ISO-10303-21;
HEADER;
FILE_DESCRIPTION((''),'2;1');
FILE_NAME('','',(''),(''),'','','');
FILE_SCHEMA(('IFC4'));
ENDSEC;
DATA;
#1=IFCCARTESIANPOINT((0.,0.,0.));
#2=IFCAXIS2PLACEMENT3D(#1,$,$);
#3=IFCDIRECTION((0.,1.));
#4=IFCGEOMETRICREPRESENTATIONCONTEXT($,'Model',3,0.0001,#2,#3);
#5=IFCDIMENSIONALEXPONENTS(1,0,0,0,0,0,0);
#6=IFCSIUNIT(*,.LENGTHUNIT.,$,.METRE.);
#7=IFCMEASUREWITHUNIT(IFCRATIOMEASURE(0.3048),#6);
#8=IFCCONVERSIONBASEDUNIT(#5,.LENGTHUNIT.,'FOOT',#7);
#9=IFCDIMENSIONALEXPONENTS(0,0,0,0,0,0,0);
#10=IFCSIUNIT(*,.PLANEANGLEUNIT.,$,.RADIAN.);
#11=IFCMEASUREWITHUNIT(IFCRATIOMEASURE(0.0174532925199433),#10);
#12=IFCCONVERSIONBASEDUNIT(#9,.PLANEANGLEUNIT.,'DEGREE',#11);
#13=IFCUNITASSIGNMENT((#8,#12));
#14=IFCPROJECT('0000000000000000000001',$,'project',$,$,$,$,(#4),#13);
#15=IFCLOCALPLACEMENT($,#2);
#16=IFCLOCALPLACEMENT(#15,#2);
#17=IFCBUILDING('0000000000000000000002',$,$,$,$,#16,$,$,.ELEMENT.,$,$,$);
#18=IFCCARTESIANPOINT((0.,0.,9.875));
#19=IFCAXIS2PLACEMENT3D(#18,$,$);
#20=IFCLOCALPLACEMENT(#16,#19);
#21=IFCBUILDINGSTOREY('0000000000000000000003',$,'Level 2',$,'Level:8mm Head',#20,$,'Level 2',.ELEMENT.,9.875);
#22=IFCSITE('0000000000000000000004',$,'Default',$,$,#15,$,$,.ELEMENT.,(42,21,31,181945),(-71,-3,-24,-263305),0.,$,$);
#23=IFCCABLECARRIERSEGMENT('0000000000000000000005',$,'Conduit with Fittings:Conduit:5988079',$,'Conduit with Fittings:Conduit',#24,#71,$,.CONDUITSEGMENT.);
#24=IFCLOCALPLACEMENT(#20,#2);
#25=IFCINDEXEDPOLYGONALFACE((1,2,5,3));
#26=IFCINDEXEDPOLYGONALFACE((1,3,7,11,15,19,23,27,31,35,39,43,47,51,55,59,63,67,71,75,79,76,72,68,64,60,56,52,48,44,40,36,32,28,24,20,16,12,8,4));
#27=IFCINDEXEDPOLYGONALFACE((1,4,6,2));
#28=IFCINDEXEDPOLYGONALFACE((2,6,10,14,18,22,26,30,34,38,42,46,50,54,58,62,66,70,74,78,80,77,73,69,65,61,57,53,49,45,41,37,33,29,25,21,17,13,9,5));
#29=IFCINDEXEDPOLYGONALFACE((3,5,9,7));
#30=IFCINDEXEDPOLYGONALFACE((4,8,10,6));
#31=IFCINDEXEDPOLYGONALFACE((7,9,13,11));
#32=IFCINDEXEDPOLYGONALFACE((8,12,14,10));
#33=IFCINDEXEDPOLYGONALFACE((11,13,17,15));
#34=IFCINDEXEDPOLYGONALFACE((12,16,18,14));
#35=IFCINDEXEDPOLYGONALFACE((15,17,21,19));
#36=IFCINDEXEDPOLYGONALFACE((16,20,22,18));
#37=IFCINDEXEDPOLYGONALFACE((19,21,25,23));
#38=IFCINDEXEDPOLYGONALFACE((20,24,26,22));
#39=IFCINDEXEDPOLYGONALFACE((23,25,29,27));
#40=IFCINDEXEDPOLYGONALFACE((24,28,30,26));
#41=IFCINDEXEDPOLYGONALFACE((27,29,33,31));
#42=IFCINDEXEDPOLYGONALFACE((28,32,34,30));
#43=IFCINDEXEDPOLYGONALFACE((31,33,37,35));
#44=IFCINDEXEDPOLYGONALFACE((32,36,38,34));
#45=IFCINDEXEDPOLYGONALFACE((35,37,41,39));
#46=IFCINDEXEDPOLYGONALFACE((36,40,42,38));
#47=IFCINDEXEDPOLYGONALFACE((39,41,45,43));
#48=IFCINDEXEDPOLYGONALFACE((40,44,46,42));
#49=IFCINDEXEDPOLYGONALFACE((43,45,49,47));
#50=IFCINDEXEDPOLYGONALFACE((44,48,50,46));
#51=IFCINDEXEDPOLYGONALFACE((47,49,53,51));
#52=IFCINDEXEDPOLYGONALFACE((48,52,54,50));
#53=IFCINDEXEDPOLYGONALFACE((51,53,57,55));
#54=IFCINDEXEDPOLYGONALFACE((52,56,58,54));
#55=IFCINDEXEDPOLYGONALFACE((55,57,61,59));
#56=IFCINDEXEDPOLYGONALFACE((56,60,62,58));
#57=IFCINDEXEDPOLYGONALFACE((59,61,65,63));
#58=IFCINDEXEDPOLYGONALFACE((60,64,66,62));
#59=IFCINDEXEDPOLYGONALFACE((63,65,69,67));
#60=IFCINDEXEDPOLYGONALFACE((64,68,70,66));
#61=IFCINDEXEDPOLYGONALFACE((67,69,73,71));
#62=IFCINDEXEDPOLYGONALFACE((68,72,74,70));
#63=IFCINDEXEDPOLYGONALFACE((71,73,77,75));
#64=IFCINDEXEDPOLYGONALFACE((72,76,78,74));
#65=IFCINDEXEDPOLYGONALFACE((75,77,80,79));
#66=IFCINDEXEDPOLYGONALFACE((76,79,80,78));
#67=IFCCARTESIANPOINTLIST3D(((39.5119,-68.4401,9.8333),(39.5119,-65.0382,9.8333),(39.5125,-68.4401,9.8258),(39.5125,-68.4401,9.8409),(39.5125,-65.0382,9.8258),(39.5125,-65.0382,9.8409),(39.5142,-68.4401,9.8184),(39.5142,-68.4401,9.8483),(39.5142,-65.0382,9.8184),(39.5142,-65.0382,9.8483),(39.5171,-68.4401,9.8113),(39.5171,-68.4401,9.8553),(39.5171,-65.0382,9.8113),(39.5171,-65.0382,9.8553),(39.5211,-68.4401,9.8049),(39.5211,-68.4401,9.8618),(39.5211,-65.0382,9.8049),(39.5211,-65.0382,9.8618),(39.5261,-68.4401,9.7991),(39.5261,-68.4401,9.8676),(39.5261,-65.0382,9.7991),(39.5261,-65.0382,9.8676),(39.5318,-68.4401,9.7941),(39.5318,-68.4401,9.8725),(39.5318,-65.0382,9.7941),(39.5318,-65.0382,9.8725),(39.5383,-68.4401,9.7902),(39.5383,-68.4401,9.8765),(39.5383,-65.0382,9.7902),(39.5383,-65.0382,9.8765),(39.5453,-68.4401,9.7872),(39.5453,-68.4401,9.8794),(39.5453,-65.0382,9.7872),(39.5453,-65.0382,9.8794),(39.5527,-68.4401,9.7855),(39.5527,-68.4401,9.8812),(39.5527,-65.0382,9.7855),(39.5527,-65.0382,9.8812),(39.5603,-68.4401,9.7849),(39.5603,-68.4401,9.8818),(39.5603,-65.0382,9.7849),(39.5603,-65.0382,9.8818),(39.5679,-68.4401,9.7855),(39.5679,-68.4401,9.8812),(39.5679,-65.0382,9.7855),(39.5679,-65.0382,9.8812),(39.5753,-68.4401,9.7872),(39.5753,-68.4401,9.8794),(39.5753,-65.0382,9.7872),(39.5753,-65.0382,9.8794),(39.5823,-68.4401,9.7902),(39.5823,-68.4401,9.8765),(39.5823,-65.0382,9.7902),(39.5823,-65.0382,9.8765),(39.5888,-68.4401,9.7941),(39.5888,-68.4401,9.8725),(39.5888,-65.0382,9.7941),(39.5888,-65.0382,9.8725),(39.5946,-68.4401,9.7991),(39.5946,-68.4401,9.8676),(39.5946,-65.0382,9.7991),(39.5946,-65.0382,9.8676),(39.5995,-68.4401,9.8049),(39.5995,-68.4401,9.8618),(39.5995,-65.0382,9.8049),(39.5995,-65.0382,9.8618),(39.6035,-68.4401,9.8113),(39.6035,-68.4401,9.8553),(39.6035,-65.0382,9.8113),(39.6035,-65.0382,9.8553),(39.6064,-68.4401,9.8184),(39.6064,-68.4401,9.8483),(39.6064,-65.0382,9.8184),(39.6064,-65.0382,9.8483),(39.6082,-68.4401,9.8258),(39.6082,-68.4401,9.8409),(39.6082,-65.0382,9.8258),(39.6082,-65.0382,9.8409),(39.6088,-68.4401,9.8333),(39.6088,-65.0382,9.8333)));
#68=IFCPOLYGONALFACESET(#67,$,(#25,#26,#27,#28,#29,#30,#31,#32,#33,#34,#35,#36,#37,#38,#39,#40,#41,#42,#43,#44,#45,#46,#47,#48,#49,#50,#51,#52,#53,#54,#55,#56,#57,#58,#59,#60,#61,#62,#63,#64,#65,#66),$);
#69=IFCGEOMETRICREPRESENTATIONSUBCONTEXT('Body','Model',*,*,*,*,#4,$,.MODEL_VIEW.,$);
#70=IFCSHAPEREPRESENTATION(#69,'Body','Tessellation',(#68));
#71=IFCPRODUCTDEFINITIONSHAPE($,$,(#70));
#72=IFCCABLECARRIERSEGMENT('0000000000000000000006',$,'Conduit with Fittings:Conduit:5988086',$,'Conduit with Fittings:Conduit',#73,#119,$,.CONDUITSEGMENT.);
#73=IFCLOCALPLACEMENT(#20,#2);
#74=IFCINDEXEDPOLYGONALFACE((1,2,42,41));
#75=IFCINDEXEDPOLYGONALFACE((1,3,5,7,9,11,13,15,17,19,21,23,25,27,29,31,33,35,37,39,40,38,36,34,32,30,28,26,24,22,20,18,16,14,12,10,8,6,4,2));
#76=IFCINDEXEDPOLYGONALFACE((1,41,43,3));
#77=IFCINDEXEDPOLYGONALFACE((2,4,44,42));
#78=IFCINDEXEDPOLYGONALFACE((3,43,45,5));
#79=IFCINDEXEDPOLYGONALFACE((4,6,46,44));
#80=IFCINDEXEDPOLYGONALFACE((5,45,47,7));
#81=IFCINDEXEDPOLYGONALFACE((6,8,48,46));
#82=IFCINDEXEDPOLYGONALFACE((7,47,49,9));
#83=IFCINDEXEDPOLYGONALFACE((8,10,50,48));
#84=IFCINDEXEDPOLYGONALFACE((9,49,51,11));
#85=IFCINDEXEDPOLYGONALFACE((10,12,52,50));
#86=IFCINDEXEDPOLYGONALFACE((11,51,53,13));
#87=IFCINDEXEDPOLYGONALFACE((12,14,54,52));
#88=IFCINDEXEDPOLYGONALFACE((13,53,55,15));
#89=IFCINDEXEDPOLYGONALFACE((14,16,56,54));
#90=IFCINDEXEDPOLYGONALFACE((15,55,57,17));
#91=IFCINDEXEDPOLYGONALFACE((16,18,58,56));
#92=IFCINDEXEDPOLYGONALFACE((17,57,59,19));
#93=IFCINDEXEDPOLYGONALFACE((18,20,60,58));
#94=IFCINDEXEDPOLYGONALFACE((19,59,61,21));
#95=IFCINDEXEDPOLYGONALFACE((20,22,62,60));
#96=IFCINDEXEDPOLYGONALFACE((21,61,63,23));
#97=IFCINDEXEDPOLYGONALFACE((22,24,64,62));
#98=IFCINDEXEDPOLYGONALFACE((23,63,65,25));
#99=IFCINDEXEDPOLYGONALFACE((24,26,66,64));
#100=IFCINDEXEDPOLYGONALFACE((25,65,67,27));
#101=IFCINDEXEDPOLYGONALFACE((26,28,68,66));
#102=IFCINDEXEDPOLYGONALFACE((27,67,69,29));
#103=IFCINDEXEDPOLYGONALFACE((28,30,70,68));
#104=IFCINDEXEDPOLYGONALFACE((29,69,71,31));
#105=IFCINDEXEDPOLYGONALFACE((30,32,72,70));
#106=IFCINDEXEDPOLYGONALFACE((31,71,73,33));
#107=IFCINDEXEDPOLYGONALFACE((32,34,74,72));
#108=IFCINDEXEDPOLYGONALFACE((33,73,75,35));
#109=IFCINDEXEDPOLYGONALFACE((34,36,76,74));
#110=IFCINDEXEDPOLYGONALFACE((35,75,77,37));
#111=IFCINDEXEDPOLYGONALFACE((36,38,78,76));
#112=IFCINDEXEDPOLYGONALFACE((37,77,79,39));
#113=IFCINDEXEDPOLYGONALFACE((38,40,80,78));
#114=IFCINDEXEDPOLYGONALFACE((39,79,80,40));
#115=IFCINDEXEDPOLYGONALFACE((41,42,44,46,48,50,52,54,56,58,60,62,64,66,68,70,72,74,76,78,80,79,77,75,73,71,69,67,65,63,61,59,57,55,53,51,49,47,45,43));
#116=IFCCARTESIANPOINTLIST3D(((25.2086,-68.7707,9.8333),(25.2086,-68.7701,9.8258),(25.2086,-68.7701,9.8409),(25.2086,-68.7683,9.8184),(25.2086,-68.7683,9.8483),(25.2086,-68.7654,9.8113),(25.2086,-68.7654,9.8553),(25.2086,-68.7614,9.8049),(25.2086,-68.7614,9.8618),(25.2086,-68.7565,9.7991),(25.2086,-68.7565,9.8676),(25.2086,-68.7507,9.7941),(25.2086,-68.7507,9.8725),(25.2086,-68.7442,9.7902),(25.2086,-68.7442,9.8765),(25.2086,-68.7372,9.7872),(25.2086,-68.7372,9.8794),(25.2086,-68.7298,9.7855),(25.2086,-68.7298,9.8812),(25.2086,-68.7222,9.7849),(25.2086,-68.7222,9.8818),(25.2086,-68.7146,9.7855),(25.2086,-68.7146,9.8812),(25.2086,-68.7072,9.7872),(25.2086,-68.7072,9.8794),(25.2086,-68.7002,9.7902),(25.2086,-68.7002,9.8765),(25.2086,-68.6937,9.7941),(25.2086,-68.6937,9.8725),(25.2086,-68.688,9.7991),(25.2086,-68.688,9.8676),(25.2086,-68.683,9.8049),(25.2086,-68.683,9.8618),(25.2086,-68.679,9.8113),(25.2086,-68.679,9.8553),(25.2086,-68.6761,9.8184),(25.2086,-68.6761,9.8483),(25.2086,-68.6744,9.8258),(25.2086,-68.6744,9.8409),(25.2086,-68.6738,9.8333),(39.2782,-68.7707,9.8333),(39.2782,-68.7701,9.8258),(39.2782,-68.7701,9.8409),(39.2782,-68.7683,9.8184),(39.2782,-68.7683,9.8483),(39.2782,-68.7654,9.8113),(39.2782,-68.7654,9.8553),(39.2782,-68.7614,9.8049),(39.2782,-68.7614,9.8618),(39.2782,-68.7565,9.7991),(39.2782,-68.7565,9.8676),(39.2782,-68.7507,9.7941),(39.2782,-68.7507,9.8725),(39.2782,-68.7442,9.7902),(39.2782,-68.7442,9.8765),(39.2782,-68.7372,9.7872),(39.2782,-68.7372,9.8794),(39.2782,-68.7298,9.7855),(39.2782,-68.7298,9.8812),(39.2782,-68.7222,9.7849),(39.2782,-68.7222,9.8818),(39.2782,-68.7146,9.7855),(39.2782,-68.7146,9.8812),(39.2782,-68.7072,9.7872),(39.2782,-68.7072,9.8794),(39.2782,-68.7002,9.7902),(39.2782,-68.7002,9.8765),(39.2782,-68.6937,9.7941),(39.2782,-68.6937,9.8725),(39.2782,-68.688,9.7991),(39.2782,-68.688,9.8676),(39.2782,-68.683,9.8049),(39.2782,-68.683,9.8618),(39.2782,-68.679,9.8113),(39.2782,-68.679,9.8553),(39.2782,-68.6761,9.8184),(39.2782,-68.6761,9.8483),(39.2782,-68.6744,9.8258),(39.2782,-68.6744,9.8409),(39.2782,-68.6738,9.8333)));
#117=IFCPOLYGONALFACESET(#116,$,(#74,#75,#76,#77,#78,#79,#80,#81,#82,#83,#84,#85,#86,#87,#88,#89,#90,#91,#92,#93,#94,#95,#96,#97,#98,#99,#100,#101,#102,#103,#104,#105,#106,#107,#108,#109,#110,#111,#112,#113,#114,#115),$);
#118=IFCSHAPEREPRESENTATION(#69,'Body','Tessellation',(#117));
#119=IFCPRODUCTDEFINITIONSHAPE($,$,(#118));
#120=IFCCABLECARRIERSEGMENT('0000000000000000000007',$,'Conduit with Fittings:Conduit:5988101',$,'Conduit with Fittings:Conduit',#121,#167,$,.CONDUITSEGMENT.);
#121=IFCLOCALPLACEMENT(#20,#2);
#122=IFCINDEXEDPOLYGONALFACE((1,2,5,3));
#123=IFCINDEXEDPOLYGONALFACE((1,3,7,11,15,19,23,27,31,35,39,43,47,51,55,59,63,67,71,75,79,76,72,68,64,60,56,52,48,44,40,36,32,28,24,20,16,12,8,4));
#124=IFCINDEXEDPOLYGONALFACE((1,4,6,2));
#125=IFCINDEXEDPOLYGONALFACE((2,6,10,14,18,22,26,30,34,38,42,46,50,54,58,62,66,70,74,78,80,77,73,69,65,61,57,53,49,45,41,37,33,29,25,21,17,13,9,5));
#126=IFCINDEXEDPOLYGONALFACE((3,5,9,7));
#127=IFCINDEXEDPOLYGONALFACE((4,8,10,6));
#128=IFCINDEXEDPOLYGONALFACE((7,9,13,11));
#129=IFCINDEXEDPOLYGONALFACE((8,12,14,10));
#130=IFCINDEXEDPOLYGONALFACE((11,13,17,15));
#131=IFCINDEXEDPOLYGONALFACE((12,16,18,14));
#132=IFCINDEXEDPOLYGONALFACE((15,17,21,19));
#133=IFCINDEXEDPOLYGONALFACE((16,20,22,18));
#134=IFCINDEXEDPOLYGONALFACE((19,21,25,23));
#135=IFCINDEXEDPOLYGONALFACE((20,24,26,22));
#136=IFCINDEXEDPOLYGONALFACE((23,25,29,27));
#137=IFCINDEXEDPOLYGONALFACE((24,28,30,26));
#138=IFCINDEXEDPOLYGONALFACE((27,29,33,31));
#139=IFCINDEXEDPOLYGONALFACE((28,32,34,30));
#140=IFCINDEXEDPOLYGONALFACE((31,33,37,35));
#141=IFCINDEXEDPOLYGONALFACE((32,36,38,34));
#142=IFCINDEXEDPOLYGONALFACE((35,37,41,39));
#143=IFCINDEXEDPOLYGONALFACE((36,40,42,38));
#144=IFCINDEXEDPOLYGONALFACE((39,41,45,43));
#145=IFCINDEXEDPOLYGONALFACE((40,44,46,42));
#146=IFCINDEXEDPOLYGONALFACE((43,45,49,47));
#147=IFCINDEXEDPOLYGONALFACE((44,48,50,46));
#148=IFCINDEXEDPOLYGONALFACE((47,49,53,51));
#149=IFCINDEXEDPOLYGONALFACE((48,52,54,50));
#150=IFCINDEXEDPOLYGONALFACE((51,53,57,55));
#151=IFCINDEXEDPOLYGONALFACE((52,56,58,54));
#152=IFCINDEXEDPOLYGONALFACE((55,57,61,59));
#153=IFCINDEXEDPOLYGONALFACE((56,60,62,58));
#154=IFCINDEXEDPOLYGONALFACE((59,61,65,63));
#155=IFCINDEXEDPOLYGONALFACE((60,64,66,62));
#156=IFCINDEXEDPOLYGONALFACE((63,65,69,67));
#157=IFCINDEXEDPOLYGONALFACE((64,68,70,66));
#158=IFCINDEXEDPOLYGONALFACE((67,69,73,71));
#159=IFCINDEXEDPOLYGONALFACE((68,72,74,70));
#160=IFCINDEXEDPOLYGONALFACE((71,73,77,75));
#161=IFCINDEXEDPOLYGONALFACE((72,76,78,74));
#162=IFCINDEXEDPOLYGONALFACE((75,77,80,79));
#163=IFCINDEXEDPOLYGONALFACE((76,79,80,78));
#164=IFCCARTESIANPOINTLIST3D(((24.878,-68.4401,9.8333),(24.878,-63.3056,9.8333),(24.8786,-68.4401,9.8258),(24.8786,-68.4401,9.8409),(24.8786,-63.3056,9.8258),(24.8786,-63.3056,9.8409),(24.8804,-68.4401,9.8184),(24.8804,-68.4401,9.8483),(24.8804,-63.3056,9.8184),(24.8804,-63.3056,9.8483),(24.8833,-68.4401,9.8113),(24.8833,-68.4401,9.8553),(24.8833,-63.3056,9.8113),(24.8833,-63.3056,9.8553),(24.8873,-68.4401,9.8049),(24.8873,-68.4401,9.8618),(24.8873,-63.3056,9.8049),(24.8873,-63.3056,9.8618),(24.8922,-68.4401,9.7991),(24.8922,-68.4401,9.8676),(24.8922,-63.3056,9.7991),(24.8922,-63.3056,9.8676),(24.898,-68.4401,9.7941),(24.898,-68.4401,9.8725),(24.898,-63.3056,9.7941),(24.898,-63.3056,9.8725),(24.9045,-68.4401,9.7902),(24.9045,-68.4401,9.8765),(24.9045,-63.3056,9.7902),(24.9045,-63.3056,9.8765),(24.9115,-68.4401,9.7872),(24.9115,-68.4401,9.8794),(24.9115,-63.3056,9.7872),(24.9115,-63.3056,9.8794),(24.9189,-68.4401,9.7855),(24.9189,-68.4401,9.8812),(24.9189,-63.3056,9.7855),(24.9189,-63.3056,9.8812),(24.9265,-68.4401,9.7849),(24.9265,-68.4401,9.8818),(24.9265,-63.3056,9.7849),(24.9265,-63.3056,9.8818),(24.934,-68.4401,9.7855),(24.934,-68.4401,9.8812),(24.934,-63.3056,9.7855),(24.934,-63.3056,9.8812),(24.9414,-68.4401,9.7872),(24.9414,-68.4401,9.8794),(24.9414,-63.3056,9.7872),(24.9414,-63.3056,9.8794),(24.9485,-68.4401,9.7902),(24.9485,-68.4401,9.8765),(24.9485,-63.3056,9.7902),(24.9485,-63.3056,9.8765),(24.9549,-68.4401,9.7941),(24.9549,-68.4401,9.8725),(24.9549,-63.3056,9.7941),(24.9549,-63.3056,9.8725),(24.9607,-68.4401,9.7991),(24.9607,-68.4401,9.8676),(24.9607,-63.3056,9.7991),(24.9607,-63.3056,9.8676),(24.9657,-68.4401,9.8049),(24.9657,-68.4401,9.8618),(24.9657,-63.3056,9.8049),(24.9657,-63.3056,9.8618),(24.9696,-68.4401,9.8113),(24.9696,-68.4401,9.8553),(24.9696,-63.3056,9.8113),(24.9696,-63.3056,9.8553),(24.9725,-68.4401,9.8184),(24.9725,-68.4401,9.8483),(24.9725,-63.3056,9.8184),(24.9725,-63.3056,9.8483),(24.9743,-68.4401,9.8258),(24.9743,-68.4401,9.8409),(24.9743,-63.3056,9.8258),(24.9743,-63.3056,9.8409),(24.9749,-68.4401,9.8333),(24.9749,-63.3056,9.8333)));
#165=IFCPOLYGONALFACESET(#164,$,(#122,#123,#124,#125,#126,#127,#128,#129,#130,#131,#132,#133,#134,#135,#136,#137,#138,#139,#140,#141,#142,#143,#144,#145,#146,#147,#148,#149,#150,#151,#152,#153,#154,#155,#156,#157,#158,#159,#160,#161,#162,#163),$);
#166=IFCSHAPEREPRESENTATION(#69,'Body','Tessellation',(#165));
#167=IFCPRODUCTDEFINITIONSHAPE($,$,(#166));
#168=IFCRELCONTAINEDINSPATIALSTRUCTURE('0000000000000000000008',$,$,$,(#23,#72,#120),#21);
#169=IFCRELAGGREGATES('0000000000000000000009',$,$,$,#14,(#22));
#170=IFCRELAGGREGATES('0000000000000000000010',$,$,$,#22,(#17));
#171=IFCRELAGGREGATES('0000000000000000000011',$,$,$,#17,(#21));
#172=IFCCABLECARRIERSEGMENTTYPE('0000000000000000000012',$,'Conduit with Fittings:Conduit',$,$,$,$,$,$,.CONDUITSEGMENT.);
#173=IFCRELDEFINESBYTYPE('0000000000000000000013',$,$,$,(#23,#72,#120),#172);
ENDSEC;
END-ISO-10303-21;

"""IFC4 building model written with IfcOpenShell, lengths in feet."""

from ifc_helpers import new_model, entity, si_unit, converted_unit, direction, frame, origin, place, context, subcontext, project, spatial, indexed_curve, outline, extrude, type_object, element, save


model = new_model("IFC4")

# Units and contexts
model_context = context("Model", 3, precision=0.0001, world=origin(), true_north=direction((0.0, 1.0)))
body_context = subcontext(model_context, "Body", "Model", "MODEL_VIEW")
ifc_project = project(units=[converted_unit("LENGTHUNIT", "FOOT", entity("IfcRatioMeasure", 0.3048), si_unit("LENGTHUNIT", "METRE"), dimensions=[1, 0, 0, 0, 0, 0, 0]), converted_unit("PLANEANGLEUNIT", "DEGREE", entity("IfcRatioMeasure", 0.0174532925199433), si_unit("PLANEANGLEUNIT", "RADIAN"), dimensions=[0, 0, 0, 0, 0, 0, 0])], contexts=[model_context])

# Site, building, storey
site_placement = place(None, origin())
site = spatial("IfcSite", under=ifc_project, at=site_placement, Name="Default", CompositionType="ELEMENT", RefLatitude=(42, 21, 31, 181945), RefLongitude=(-71, -3, -24, -263305), RefElevation=0.0)
building_placement = place(site_placement, origin())
building = spatial("IfcBuilding", under=site, at=building_placement, CompositionType="ELEMENT")
storey_placement = place(building_placement, frame((0.0, 0.0, 9.875)))
storey = spatial("IfcBuildingStorey", under=building, at=storey_placement, Name="Level 2", ObjectType="Level:8mm Head", LongName="Level 2", CompositionType="ELEMENT", Elevation=9.875)

# Cable carrier segments
cable_carrier_segment_type = type_object("IfcCableCarrierSegmentType", Name="Conduit with Fittings:Conduit", PredefinedType="CONDUITSEGMENT")
cable_carrier_segment_1_placement = place(storey_placement, origin())
element("IfcCableCarrierSegment", 1, at=cable_carrier_segment_1_placement, inside=storey, type_object=cable_carrier_segment_type, Name="Conduit with Fittings:Conduit:5988079", ObjectType="Conduit with Fittings:Conduit", PredefinedType="CONDUITSEGMENT", context=body_context, shape_type="SweptSolid", body=[
    extrude(outline(indexed_curve([(0.0485, 0.0), (0.0479, 0.0076), (0.0461, 0.015), (0.0432, 0.022), (0.0392, 0.0285), (0.0343, 0.0343), (0.0285, 0.0392), (0.022, 0.0432), (0.015, 0.0461), (0.0076, 0.0479), (0.0, 0.0485), (-0.0076, 0.0479), (-0.015, 0.0461), (-0.022, 0.0432), (-0.0285, 0.0392), (-0.0343, 0.0343), (-0.0392, 0.0285), (-0.0432, 0.022), (-0.0461, 0.015), (-0.0479, 0.0076), (-0.0485, 0.0), (-0.0479, -0.0076), (-0.0461, -0.015), (-0.0432, -0.022), (-0.0392, -0.0285), (-0.0343, -0.0343), (-0.0285, -0.0392), (-0.022, -0.0432), (-0.015, -0.0461), (-0.0076, -0.0479), (0.0, -0.0485), (0.0076, -0.0479), (0.015, -0.0461), (0.022, -0.0432), (0.0285, -0.0392), (0.0343, -0.0343), (0.0392, -0.0285), (0.0432, -0.022), (0.0461, -0.015), (0.0479, -0.0076), (0.0485, 0.0)], self_intersect=False)), frame((39.5603, -68.4401, 9.8333), z_axis=(0.0, 1.0, 0.0), x_axis=(-1.0, 0.0, 0.0)), (0.0, 0.0, 1.0), 3.4019),
])
cable_carrier_segment_2_placement = place(storey_placement, origin())
element("IfcCableCarrierSegment", 2, at=cable_carrier_segment_2_placement, inside=storey, type_object=cable_carrier_segment_type, Name="Conduit with Fittings:Conduit:5988086", ObjectType="Conduit with Fittings:Conduit", PredefinedType="CONDUITSEGMENT", context=body_context, shape_type="SweptSolid", body=[
    extrude(outline(indexed_curve([(0.0485, 0.0), (0.0479, 0.0076), (0.0461, 0.015), (0.0432, 0.022), (0.0392, 0.0285), (0.0343, 0.0343), (0.0285, 0.0392), (0.022, 0.0432), (0.015, 0.0461), (0.0076, 0.0479), (0.0, 0.0485), (-0.0076, 0.0479), (-0.015, 0.0461), (-0.022, 0.0432), (-0.0285, 0.0392), (-0.0343, 0.0343), (-0.0392, 0.0285), (-0.0432, 0.022), (-0.0461, 0.015), (-0.0479, 0.0076), (-0.0485, 0.0), (-0.0479, -0.0076), (-0.0461, -0.015), (-0.0432, -0.022), (-0.0392, -0.0285), (-0.0343, -0.0343), (-0.0285, -0.0392), (-0.022, -0.0432), (-0.015, -0.0461), (-0.0076, -0.0479), (0.0, -0.0485), (0.0076, -0.0479), (0.015, -0.0461), (0.022, -0.0432), (0.0285, -0.0392), (0.0343, -0.0343), (0.0392, -0.0285), (0.0432, -0.022), (0.0461, -0.015), (0.0479, -0.0076), (0.0485, 0.0)], self_intersect=False)), frame((25.2086, -68.7222, 9.8333), z_axis=(1.0, 0.0, 0.0), x_axis=(0.0, 1.0, 0.0)), (0.0, 0.0, 1.0), 14.0696),
])
cable_carrier_segment_3_placement = place(storey_placement, origin())
element("IfcCableCarrierSegment", 3, at=cable_carrier_segment_3_placement, inside=storey, type_object=cable_carrier_segment_type, Name="Conduit with Fittings:Conduit:5988101", ObjectType="Conduit with Fittings:Conduit", PredefinedType="CONDUITSEGMENT", context=body_context, shape_type="SweptSolid", body=[
    extrude(outline(indexed_curve([(0.0485, 0.0), (0.0479, 0.0076), (0.0461, 0.015), (0.0432, 0.022), (0.0392, 0.0285), (0.0343, 0.0343), (0.0285, 0.0392), (0.022, 0.0432), (0.015, 0.0461), (0.0076, 0.0479), (0.0, 0.0485), (-0.0076, 0.0479), (-0.015, 0.0461), (-0.022, 0.0432), (-0.0285, 0.0392), (-0.0343, 0.0343), (-0.0392, 0.0285), (-0.0432, 0.022), (-0.0461, 0.015), (-0.0479, 0.0076), (-0.0485, 0.0), (-0.0479, -0.0076), (-0.0461, -0.015), (-0.0432, -0.022), (-0.0392, -0.0285), (-0.0343, -0.0343), (-0.0285, -0.0392), (-0.022, -0.0432), (-0.015, -0.0461), (-0.0076, -0.0479), (0.0, -0.0485), (0.0076, -0.0479), (0.015, -0.0461), (0.022, -0.0432), (0.0285, -0.0392), (0.0343, -0.0343), (0.0392, -0.0285), (0.0432, -0.022), (0.0461, -0.015), (0.0479, -0.0076), (0.0485, 0.0)], self_intersect=False)), frame((24.9265, -68.4401, 9.8333), z_axis=(0.0, 1.0, 0.0), x_axis=(1.0, 0.0, 0.0)), (0.0, 0.0, 1.0), 5.1345),
])

save(model, "model.ifc")
